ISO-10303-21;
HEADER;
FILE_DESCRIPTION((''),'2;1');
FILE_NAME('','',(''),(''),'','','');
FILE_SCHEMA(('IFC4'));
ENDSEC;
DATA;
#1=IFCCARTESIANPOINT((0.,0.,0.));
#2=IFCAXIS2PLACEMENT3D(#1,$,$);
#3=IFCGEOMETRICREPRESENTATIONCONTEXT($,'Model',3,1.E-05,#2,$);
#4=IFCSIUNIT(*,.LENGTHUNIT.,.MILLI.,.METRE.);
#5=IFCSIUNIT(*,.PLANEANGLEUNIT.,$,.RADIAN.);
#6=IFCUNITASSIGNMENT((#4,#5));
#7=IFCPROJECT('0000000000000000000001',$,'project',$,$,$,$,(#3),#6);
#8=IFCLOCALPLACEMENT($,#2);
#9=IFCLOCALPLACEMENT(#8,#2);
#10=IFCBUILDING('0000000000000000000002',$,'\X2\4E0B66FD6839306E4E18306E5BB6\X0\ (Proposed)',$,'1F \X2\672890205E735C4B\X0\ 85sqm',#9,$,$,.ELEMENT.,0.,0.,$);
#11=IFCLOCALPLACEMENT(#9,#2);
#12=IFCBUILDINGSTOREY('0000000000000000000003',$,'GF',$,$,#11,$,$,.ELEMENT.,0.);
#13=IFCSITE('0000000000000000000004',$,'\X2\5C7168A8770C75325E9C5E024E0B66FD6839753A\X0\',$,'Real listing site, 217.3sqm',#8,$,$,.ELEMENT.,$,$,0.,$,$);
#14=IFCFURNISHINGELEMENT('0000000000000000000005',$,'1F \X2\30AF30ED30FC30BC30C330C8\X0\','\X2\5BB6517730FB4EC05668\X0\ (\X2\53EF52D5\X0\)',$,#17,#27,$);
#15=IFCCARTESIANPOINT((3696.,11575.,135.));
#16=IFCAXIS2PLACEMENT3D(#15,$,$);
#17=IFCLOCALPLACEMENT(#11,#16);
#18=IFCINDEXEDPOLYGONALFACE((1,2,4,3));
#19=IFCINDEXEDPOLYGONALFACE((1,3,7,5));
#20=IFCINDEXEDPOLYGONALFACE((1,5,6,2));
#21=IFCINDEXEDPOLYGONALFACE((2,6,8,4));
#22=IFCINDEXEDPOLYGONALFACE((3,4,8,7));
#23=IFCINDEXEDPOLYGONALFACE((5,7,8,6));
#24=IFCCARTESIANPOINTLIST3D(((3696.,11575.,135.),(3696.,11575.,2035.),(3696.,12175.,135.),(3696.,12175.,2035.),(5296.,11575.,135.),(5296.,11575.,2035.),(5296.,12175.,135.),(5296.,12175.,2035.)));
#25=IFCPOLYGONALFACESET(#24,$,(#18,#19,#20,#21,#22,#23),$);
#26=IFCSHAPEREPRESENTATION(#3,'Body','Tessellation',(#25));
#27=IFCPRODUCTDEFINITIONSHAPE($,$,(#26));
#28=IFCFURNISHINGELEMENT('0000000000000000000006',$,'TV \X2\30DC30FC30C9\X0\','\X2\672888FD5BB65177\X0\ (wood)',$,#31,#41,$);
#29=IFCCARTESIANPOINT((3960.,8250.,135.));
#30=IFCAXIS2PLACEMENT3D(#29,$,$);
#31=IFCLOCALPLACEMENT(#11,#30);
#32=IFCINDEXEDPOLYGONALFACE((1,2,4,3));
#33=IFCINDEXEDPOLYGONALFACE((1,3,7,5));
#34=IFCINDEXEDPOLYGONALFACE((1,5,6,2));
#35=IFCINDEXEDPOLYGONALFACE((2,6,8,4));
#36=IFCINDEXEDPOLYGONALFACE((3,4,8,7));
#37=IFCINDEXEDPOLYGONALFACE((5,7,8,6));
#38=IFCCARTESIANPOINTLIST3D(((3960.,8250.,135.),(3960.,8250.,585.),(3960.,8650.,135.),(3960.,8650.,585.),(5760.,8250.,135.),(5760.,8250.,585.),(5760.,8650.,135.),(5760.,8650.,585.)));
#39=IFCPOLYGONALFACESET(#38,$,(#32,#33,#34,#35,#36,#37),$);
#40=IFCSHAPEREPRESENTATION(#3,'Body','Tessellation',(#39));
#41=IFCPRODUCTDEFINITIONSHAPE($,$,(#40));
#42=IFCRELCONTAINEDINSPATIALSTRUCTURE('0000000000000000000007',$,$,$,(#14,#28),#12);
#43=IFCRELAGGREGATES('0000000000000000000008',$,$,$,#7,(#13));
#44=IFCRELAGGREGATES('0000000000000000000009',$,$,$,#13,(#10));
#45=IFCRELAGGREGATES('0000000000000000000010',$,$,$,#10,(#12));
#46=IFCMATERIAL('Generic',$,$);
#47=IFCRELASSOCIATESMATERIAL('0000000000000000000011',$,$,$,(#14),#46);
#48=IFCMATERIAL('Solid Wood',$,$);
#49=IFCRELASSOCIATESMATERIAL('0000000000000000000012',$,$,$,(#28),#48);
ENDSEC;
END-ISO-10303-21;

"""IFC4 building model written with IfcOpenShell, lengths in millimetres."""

from ifc_helpers import new_model, si_unit, frame, frame_2d, origin, place, context, project, spatial, rectangle, extrude, material, element, save


model = new_model("IFC4")

# Units and contexts
model_context = context("Model", 3, precision=1e-05, world=origin())
ifc_project = project(units=[si_unit("LENGTHUNIT", "METRE", prefix="MILLI"), si_unit("PLANEANGLEUNIT", "RADIAN")], contexts=[model_context])

# Site, building, storey
site_placement = place(None, origin())
site = spatial("IfcSite", under=ifc_project, at=site_placement, Name="山梨県甲府市下曽根町", ObjectType="Real listing site, 217.3sqm", CompositionType="ELEMENT", RefElevation=0.0)
building_placement = place(site_placement, origin())
building = spatial("IfcBuilding", under=site, at=building_placement, Name="下曽根の丘の家 (Proposed)", ObjectType="1F 木造平屋 85sqm", CompositionType="ELEMENT", ElevationOfRefHeight=0.0, ElevationOfTerrain=0.0)
storey_placement = place(building_placement, origin())
storey = spatial("IfcBuildingStorey", under=building, at=storey_placement, Name="GF", CompositionType="ELEMENT", Elevation=0.0)

# Shared definitions
ifc_material_1 = material(Name="Solid Wood")

# Shared definitions
ifc_material_2 = material(Name="Generic")

# Furnishing elements
furnishing_1_placement = place(storey_placement, frame((3696.0, 11575.0, 135.0)))
element("IfcFurnishingElement", 1, at=furnishing_1_placement, inside=storey, material=ifc_material_2, Name="1F クローゼット", Description="家具・什器 (可動)", context=model_context, shape_type="SweptSolid", body=[
    extrude(rectangle(XDim=1600.0, YDim=600.0, at=frame_2d((800.0, 300.0))), frame((3696.0, 11575.0, 135.0)), (0.0, 0.0, 1.0), 1900.0),
])
furnishing_2_placement = place(storey_placement, frame((3960.0, 8250.0, 135.0)))
element("IfcFurnishingElement", 2, at=furnishing_2_placement, inside=storey, material=ifc_material_1, Name="TV ボード", Description="木製家具 (wood)", context=model_context, shape_type="SweptSolid", body=[
    extrude(rectangle(XDim=1800.0, YDim=400.0, at=frame_2d((900.0, 200.0))), frame((3960.0, 8250.0, 135.0)), (0.0, 0.0, 1.0), 450.0),
])

save(model, "model.ifc")
